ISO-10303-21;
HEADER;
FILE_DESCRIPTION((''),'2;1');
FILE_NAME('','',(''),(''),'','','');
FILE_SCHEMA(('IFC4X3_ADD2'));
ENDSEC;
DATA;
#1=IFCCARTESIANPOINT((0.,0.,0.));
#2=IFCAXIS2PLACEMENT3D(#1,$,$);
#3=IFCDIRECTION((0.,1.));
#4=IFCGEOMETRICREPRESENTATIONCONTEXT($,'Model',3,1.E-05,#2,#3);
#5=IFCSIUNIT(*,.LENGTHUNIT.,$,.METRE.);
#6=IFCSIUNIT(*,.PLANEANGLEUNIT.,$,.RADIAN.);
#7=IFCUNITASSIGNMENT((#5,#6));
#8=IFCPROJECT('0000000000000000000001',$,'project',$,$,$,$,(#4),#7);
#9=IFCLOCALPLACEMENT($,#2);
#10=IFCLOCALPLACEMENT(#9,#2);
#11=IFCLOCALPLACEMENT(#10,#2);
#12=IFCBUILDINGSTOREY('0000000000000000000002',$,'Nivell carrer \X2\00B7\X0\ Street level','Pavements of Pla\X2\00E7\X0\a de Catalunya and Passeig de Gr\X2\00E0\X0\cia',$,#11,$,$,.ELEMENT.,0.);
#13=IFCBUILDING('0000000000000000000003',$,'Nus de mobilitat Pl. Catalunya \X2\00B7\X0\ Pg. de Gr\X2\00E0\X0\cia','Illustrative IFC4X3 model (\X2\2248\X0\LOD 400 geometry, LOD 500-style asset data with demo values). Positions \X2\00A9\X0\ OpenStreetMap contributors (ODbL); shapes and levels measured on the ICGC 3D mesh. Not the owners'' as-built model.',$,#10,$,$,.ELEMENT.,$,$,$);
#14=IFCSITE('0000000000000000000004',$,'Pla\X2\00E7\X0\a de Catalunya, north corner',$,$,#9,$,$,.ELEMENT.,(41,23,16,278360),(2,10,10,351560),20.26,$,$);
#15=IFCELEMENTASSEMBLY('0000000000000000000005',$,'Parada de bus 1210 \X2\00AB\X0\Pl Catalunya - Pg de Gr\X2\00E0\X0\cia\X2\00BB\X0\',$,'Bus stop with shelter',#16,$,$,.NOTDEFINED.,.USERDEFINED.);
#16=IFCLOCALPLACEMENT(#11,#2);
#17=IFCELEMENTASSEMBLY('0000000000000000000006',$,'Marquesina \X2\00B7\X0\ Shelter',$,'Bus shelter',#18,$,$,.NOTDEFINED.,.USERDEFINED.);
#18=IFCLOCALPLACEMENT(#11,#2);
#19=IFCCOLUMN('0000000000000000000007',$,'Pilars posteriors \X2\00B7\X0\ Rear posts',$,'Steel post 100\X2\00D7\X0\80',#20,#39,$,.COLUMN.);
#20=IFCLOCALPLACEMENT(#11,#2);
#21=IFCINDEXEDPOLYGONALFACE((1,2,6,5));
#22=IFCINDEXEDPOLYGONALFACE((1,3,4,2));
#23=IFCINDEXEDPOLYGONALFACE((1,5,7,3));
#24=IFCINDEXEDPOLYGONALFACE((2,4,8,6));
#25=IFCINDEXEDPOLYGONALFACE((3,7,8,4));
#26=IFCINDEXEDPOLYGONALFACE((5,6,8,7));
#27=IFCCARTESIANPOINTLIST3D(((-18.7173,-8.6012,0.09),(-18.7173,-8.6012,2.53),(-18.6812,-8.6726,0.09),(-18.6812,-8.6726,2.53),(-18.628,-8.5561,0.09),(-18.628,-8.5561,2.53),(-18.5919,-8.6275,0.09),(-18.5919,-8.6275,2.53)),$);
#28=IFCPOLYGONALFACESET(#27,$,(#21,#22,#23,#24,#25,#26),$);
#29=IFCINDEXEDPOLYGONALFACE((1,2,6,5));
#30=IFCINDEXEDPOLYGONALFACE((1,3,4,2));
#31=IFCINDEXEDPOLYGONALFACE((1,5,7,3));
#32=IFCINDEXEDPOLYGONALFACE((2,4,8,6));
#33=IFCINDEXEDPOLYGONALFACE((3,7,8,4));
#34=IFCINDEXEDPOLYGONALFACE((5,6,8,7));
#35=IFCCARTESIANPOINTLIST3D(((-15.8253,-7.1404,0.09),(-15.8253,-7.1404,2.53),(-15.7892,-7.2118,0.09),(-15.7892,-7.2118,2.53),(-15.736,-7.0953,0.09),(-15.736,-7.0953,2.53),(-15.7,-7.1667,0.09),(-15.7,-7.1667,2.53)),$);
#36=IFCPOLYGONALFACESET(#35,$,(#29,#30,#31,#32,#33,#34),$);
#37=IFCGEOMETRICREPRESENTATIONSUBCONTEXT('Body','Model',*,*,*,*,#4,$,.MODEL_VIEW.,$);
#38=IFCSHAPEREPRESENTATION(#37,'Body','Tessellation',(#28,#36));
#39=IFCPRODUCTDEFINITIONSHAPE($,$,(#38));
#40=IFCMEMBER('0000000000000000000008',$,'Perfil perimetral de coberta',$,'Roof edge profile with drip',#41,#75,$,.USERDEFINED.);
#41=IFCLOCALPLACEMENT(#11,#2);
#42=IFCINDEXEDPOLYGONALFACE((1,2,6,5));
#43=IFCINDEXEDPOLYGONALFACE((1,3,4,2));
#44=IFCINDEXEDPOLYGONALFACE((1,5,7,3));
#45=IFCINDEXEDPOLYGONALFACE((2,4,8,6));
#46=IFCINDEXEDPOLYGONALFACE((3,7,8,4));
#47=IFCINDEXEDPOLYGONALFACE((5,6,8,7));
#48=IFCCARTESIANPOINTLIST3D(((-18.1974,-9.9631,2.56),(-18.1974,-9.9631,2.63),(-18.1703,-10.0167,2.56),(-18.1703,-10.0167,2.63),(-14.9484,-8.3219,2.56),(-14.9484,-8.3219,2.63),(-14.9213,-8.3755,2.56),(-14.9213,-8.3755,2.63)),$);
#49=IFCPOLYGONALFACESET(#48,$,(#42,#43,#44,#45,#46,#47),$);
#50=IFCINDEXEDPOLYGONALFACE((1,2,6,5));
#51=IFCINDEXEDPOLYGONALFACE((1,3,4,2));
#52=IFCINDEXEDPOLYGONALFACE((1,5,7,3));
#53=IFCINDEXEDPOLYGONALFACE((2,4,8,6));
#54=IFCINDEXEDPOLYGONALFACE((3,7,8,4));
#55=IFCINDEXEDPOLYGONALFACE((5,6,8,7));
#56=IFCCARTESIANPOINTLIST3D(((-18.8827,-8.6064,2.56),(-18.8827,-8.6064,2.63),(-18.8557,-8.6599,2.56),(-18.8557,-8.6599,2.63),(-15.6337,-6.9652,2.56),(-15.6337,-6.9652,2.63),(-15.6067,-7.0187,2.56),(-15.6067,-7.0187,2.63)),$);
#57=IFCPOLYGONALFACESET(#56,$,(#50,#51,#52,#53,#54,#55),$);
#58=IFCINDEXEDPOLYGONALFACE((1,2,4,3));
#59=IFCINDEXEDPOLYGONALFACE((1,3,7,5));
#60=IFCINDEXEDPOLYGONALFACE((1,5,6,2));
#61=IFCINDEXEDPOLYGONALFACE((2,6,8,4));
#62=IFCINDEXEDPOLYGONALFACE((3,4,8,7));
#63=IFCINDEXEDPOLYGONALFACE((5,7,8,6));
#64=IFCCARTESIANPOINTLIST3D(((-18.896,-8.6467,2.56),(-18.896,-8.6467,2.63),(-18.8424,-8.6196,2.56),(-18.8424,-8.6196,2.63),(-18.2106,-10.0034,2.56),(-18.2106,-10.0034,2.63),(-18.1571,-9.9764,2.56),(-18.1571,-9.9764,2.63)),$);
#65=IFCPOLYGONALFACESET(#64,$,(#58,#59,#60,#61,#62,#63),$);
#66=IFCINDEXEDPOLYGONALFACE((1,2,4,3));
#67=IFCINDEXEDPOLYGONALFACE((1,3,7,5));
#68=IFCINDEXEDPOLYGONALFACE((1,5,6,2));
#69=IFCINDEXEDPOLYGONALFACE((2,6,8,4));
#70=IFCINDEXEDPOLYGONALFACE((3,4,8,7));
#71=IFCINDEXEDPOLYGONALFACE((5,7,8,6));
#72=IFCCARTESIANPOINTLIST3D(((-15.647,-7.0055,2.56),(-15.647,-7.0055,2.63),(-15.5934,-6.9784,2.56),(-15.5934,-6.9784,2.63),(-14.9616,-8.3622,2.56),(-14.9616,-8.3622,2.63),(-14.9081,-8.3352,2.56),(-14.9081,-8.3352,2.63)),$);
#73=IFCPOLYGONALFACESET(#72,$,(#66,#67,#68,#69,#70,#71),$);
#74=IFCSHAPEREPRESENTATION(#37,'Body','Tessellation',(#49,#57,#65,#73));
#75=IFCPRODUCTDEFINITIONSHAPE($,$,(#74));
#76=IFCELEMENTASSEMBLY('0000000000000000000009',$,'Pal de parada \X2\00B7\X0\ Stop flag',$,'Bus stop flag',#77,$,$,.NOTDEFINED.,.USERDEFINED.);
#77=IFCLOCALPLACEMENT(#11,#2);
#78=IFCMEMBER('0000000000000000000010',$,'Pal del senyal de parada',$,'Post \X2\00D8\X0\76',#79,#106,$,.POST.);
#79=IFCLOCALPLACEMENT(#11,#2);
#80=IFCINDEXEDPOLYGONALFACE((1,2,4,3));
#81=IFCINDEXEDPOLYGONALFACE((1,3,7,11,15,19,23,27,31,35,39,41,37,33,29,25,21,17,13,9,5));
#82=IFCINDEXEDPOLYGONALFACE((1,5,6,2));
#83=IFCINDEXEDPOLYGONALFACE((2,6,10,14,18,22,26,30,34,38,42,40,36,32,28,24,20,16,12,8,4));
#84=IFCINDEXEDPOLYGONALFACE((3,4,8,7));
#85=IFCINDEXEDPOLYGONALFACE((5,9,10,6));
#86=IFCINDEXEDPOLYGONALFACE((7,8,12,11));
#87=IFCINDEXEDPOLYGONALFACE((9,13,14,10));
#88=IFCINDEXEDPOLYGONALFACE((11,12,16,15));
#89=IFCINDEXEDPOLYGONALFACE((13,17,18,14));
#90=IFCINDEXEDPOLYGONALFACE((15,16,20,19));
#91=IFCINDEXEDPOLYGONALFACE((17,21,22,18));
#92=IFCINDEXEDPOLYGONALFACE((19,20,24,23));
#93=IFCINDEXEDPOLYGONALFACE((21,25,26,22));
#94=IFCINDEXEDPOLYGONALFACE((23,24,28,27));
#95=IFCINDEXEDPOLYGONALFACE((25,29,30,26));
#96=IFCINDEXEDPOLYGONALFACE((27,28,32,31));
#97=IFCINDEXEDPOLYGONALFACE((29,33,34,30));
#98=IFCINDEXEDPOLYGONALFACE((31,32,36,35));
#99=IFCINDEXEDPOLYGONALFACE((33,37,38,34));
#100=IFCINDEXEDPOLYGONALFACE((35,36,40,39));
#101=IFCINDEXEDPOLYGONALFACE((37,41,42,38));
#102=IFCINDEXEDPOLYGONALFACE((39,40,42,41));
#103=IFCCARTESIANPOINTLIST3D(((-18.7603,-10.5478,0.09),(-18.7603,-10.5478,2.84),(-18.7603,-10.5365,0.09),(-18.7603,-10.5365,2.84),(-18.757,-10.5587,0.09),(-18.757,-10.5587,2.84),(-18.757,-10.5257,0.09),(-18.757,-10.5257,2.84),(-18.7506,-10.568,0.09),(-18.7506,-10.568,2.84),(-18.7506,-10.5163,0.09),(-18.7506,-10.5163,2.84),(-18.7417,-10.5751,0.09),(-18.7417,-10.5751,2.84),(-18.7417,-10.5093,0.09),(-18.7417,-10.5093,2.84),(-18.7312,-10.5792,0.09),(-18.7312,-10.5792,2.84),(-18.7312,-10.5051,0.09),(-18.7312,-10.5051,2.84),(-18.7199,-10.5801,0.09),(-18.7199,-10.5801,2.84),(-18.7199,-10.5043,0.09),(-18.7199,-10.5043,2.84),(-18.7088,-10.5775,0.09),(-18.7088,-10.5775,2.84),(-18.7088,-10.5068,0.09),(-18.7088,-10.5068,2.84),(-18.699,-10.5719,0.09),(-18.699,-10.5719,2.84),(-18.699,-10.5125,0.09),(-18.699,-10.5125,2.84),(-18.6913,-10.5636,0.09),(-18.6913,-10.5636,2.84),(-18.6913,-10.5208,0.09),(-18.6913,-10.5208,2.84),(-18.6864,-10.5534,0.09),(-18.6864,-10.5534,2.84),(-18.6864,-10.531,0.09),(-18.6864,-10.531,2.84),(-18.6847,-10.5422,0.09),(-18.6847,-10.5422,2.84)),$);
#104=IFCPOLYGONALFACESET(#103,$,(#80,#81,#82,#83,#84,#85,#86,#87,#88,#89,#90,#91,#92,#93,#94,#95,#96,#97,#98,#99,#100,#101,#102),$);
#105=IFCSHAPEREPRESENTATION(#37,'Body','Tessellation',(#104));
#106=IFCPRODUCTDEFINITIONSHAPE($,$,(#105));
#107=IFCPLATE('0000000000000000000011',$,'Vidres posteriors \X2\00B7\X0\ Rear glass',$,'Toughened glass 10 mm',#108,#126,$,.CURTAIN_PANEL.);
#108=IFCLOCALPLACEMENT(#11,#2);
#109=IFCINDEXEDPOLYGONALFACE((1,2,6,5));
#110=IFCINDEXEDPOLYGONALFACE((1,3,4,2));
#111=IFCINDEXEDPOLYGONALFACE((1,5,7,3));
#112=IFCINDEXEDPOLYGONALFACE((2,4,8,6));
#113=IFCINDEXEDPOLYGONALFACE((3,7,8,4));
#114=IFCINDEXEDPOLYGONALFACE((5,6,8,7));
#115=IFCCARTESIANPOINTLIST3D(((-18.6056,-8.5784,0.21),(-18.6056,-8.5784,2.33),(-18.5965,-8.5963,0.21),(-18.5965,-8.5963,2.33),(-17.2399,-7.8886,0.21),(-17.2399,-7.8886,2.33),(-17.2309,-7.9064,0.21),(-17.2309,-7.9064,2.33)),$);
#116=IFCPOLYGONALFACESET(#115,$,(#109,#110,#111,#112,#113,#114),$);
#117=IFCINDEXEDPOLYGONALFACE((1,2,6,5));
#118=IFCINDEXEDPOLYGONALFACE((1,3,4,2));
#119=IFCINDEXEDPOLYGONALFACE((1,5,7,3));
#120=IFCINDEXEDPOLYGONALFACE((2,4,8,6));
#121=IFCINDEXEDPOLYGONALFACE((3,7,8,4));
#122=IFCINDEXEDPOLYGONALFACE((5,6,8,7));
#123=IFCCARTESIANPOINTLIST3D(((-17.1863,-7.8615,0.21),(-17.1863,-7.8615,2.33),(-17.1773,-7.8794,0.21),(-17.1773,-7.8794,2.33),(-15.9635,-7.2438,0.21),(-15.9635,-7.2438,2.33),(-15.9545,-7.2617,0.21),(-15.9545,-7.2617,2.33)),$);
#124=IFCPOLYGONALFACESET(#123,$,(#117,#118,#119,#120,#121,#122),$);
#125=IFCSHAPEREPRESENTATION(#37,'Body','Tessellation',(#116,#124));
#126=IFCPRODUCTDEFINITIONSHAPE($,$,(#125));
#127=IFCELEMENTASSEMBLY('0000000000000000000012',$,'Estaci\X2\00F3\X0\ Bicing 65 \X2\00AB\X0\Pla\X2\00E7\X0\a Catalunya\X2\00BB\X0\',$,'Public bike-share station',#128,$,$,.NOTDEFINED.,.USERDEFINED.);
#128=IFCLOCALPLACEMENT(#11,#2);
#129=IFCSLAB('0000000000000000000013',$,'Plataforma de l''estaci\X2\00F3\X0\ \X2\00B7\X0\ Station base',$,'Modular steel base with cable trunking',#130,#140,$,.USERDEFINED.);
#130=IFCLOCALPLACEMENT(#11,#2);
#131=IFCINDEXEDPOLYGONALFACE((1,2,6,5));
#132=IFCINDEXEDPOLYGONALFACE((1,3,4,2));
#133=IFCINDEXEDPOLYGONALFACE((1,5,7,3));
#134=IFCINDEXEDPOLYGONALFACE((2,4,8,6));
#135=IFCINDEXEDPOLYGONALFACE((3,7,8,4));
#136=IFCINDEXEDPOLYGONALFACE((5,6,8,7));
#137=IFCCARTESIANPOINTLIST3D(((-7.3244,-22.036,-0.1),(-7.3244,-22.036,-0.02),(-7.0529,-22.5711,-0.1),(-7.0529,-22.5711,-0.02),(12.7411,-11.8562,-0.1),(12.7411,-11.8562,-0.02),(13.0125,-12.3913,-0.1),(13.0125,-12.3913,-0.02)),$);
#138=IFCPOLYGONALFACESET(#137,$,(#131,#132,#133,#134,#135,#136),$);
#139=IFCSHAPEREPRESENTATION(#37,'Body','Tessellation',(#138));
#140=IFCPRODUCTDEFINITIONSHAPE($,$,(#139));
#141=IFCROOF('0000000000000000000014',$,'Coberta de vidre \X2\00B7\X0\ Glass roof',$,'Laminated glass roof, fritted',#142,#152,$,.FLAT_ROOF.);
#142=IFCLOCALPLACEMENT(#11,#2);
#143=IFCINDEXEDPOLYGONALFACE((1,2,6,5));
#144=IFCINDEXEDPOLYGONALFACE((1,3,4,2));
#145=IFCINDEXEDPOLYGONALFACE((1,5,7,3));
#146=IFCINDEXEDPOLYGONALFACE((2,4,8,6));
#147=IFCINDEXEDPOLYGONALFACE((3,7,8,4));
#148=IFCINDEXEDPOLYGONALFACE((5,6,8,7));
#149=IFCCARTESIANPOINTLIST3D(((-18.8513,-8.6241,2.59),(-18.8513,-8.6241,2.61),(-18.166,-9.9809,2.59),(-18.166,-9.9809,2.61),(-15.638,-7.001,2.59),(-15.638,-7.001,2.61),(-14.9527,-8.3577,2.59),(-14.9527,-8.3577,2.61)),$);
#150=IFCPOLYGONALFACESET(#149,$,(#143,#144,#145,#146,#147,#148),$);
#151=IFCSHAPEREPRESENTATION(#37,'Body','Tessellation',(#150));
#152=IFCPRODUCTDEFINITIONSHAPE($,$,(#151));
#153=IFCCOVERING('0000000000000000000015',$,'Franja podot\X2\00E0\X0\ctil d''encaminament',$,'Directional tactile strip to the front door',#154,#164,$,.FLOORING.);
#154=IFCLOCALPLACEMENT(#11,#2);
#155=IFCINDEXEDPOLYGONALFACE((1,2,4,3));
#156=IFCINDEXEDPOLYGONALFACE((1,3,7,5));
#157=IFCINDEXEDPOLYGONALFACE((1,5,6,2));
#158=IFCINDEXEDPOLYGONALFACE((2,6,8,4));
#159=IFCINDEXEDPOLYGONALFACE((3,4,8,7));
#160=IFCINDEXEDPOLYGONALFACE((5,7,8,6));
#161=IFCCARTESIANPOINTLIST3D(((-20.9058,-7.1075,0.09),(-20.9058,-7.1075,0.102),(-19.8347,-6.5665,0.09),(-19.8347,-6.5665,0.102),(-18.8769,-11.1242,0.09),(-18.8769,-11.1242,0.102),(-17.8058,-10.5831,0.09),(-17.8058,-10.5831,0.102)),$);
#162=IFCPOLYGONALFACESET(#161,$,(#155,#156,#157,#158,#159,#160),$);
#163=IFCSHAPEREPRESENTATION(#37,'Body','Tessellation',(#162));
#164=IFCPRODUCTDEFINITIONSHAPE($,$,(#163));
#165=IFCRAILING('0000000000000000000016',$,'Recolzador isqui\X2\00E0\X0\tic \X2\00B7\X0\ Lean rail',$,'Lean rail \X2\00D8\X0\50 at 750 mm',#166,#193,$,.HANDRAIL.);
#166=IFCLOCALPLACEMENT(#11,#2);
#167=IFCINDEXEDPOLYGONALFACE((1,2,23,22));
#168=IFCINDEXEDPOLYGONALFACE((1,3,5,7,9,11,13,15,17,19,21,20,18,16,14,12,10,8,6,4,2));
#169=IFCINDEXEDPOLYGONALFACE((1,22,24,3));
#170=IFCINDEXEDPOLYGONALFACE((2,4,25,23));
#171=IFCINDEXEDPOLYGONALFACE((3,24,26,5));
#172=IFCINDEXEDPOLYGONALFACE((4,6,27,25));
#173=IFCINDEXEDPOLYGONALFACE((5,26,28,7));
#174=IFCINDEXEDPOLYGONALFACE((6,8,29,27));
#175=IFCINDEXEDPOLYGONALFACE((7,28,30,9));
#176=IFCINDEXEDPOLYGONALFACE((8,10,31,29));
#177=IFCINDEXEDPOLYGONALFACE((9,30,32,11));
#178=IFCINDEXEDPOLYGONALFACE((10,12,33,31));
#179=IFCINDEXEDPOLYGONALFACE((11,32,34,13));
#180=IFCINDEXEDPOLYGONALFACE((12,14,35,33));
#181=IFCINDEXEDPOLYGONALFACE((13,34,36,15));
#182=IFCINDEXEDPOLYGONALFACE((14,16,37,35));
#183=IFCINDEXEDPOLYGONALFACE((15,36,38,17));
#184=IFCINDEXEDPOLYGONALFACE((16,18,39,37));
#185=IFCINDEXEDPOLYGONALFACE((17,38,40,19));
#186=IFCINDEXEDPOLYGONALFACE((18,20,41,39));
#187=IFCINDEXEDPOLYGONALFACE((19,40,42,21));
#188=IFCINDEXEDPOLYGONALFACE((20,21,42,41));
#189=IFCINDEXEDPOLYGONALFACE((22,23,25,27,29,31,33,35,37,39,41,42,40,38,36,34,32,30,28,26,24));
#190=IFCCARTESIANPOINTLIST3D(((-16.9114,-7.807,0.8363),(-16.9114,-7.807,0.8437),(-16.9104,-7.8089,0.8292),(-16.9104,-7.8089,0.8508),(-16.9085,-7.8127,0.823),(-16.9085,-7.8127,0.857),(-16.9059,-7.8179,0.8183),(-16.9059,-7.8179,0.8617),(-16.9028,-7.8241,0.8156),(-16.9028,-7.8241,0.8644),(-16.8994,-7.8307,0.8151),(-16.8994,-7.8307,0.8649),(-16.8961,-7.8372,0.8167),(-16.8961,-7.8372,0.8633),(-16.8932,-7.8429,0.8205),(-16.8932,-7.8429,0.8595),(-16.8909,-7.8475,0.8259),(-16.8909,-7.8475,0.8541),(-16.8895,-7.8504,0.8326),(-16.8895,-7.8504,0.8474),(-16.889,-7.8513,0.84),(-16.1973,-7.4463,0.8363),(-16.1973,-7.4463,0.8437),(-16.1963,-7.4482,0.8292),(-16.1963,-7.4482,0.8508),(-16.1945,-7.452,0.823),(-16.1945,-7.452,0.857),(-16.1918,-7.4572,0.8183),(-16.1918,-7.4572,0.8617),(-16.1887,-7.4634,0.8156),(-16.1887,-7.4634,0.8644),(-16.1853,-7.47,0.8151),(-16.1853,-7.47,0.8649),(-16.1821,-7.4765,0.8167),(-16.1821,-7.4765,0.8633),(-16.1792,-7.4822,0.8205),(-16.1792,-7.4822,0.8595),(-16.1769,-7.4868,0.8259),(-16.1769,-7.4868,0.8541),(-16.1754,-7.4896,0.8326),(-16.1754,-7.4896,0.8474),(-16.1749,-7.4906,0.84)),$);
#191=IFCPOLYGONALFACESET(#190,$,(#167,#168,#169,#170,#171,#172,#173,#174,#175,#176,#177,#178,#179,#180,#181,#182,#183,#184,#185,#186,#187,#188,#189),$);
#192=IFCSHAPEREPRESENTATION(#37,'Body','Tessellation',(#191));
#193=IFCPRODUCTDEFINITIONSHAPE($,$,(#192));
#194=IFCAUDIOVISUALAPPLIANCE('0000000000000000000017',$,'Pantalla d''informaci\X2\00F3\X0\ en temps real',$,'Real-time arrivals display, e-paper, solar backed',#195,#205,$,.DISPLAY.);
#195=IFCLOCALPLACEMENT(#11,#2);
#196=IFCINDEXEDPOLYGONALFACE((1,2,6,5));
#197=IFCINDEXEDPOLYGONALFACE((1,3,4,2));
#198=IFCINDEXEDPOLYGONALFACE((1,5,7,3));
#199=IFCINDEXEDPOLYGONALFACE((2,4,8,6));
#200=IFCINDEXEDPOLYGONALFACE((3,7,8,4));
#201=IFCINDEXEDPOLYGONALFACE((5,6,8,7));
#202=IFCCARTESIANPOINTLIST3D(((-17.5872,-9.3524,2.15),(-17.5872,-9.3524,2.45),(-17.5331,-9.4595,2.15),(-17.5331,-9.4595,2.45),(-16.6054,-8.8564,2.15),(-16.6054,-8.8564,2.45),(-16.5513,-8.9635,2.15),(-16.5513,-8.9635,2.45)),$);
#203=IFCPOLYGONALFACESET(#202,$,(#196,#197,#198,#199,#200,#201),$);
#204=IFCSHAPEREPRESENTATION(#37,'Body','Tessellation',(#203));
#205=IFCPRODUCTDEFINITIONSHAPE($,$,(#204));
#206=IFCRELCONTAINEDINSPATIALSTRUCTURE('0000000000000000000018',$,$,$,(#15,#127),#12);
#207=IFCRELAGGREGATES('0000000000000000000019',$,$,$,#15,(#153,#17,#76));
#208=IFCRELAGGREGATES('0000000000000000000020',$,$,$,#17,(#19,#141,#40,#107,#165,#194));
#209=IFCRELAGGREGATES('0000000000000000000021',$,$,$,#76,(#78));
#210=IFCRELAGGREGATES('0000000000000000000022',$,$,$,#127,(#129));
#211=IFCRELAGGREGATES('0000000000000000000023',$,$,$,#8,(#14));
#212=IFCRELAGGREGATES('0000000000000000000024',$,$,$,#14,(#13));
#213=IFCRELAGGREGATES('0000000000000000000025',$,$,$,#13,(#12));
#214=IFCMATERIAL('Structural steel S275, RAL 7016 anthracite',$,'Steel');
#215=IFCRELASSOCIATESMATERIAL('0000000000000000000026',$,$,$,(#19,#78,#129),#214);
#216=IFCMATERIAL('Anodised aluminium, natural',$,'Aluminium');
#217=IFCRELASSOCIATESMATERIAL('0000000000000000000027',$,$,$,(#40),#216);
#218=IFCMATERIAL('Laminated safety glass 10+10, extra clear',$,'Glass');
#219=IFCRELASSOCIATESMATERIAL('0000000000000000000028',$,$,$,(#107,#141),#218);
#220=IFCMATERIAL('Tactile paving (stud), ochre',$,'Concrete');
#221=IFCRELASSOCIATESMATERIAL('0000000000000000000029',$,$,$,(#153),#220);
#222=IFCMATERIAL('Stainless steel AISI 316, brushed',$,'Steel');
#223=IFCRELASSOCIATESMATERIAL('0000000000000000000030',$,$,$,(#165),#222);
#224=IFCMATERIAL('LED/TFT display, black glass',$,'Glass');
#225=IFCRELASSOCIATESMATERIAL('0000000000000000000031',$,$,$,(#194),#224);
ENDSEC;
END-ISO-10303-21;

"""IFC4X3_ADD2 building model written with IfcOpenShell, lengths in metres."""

from ifc_helpers import new_model, si_unit, direction, frame, frame_2d, origin, origin_2d_with_axis, place, context, subcontext, project, spatial, rectangle, circle, extrude, material, element, aggregate, save


model = new_model("IFC4X3_ADD2")

# Units and contexts
model_context = context("Model", 3, precision=1e-05, world=origin(), true_north=direction((0.0, 1.0)))
body_context = subcontext(model_context, "Body", "Model", "MODEL_VIEW")
ifc_project = project(units=[si_unit("LENGTHUNIT", "METRE"), si_unit("PLANEANGLEUNIT", "RADIAN")], contexts=[model_context])

# Site, building, storey
site_placement = place(None, origin())
site = spatial("IfcSite", under=ifc_project, at=site_placement, Name="Plaça de Catalunya, north corner", CompositionType="ELEMENT", RefLatitude=(41, 23, 16, 278360), RefLongitude=(2, 10, 10, 351560), RefElevation=20.26)
building_placement = place(site_placement, origin())
building = spatial("IfcBuilding", under=site, at=building_placement, Name="Nus de mobilitat Pl. Catalunya · Pg. de Gràcia", Description="Illustrative IFC4X3 model (≈LOD 400 geometry, LOD 500-style asset data with demo values). Positions © OpenStreetMap contributors (ODbL); shapes and levels measured on the ICGC 3D mesh. Not the owners' as-built model.", CompositionType="ELEMENT")
storey_placement = place(building_placement, origin())
storey = spatial("IfcBuildingStorey", under=building, at=storey_placement, Name="Nivell carrer · Street level", Description="Pavements of Plaça de Catalunya and Passeig de Gràcia", CompositionType="ELEMENT", Elevation=0.0)

# Element assemblies, column, members, plate
assembly_1_placement = place(building_placement, origin())
assembly_1 = element("IfcElementAssembly", 1, at=assembly_1_placement, inside=storey, Name="Parada de bus 1210 «Pl Catalunya - Pg de Gràcia»", ObjectType="Bus stop with shelter", AssemblyPlace="NOTDEFINED", PredefinedType="USERDEFINED")
assembly_2_placement = place(building_placement, origin())
assembly_2 = element("IfcElementAssembly", 2, at=assembly_2_placement, Name="Marquesina · Shelter", ObjectType="Bus shelter", AssemblyPlace="NOTDEFINED", PredefinedType="USERDEFINED")
ifc_material_1 = material(Name="Structural steel S275, RAL 7016 anthracite", Category="Steel")
column_placement = place(building_placement, origin())
column = element("IfcColumn", 3, at=column_placement, material=ifc_material_1, Name="Pilars posteriors · Rear posts", ObjectType="Steel post 100×80", PredefinedType="COLUMN", context=body_context, shape_type="SweptSolid", body=[
    extrude(rectangle(XDim=0.1, YDim=0.08, at=frame_2d((0.0, 0.0), x_axis=(0.892586, 0.450878))), frame((-18.6546, -8.6144, 0.09)), (0.0, 0.0, 1.0), 2.44),
    extrude(rectangle(XDim=0.1, YDim=0.08, at=frame_2d((0.0, 0.0), x_axis=(0.892586, 0.450878))), frame((-15.7626, -7.1535, 0.09)), (0.0, 0.0, 1.0), 2.44),
])
ifc_material_2 = material(Name="Anodised aluminium, natural", Category="Aluminium")
member_1_placement = place(building_placement, origin())
member_1 = element("IfcMember", 4, at=member_1_placement, material=ifc_material_2, Name="Perfil perimetral de coberta", ObjectType="Roof edge profile with drip", PredefinedType="USERDEFINED", context=body_context, shape_type="SweptSolid", body=[
    extrude(rectangle(XDim=3.64, YDim=0.06, at=frame_2d((0.0, 0.0), x_axis=(0.892586, 0.450878))), frame((-16.5594, -9.1693, 2.56)), (0.0, 0.0, 1.0), 0.07),
    extrude(rectangle(XDim=3.64, YDim=0.06, at=frame_2d((0.0, 0.0), x_axis=(0.892586, 0.450878))), frame((-17.2447, -7.8126, 2.56)), (0.0, 0.0, 1.0), 0.07),
    extrude(rectangle(XDim=0.06, YDim=1.52, at=frame_2d((0.0, 0.0), x_axis=(0.892586, 0.450878))), frame((-18.5265, -9.3115, 2.56)), (0.0, 0.0, 1.0), 0.07),
    extrude(rectangle(XDim=0.06, YDim=1.52, at=frame_2d((0.0, 0.0), x_axis=(0.892586, 0.450878))), frame((-15.2775, -7.6703, 2.56)), (0.0, 0.0, 1.0), 0.07),
])
assembly_3_placement = place(building_placement, origin())
assembly_3 = element("IfcElementAssembly", 5, at=assembly_3_placement, Name="Pal de parada · Stop flag", ObjectType="Bus stop flag", AssemblyPlace="NOTDEFINED", PredefinedType="USERDEFINED")
member_2_placement = place(building_placement, origin())
member_2 = element("IfcMember", 6, at=member_2_placement, material=ifc_material_1, Name="Pal del senyal de parada", ObjectType="Post Ø76", PredefinedType="POST", context=body_context, shape_type="SweptSolid", body=[
    extrude(circle(Radius=0.038, at=origin_2d_with_axis()), frame((-18.7227, -10.5422, 0.09)), (0.0, 0.0, 1.0), 2.75),
])
ifc_material_3 = material(Name="Laminated safety glass 10+10, extra clear", Category="Glass")
plate_placement = place(building_placement, origin())
plate = element("IfcPlate", 7, at=plate_placement, material=ifc_material_3, Name="Vidres posteriors · Rear glass", ObjectType="Toughened glass 10 mm", PredefinedType="CURTAIN_PANEL", context=body_context, shape_type="SweptSolid", body=[
    extrude(rectangle(XDim=1.53, YDim=0.02, at=frame_2d((0.0, 0.0), x_axis=(0.892586, 0.450878))), frame((-17.9182, -8.2424, 0.21)), (0.0, 0.0, 1.0), 2.12),
    extrude(rectangle(XDim=1.37, YDim=0.02, at=frame_2d((0.0, 0.0), x_axis=(0.892586, 0.450878))), frame((-16.5704, -7.5616, 0.21)), (0.0, 0.0, 1.0), 2.12),
])

# Element assembly, slab
assembly_4_placement = place(building_placement, origin())
assembly_4 = element("IfcElementAssembly", 8, at=assembly_4_placement, inside=storey, Name="Estació Bicing 65 «Plaça Catalunya»", ObjectType="Public bike-share station", AssemblyPlace="NOTDEFINED", PredefinedType="USERDEFINED")
slab_placement = place(building_placement, origin())
slab = element("IfcSlab", 9, at=slab_placement, material=ifc_material_1, Name="Plataforma de l'estació · Station base", ObjectType="Modular steel base with cable trunking", PredefinedType="USERDEFINED", context=body_context, shape_type="SweptSolid", body=[
    extrude(rectangle(XDim=22.5, YDim=0.6, at=frame_2d((0.0, 0.0), x_axis=(0.891798, 0.452435))), frame((2.8441, -17.2136, -0.1)), (0.0, 0.0, 1.0), 0.08),
])

# Roof
roof_placement = place(building_placement, origin())
roof = element("IfcRoof", 10, at=roof_placement, material=ifc_material_3, Name="Coberta de vidre · Glass roof", ObjectType="Laminated glass roof, fritted", PredefinedType="FLAT_ROOF", context=body_context, shape_type="SweptSolid", body=[
    extrude(rectangle(XDim=3.6, YDim=1.52, at=frame_2d((0.0, 0.0), x_axis=(0.892586, 0.450878))), frame((-16.902, -8.4909, 2.59)), (0.0, 0.0, 1.0), 0.02),
])

# Covering
ifc_material_4 = material(Name="Tactile paving (stud), ochre", Category="Concrete")
covering_placement = place(building_placement, origin())
covering = element("IfcCovering", 11, at=covering_placement, material=ifc_material_4, Name="Franja podotàctil d'encaminament", ObjectType="Directional tactile strip to the front door", PredefinedType="FLOORING", context=body_context, shape_type="SweptSolid", body=[
    extrude(rectangle(XDim=1.2, YDim=4.5, at=frame_2d((0.0, 0.0), x_axis=(0.892586, 0.450878))), frame((-19.3558, -8.8453, 0.09)), (0.0, 0.0, 1.0), 0.012),
])

# Railing
ifc_material_5 = material(Name="Stainless steel AISI 316, brushed", Category="Steel")
railing_placement = place(building_placement, origin())
railing = element("IfcRailing", 12, at=railing_placement, material=ifc_material_5, Name="Recolzador isquiàtic · Lean rail", ObjectType="Lean rail Ø50 at 750 mm", PredefinedType="HANDRAIL", context=body_context, shape_type="SweptSolid", body=[
    extrude(circle(Radius=0.025, at=origin_2d_with_axis()), frame((-16.9003, -7.829, 0.84), z_axis=(0.892586, 0.450878, 0.0), x_axis=(0.450878, -0.892586, 0.0)), (0.0, 0.0, 1.0), 0.8),
])

# Audio visual appliance
ifc_material_6 = material(Name="LED/TFT display, black glass", Category="Glass")
audio_visual_appliance_placement = place(building_placement, origin())
audio_visual_appliance = element("IfcAudioVisualAppliance", 13, at=audio_visual_appliance_placement, material=ifc_material_6, Name="Pantalla d'informació en temps real", ObjectType="Real-time arrivals display, e-paper, solar backed", PredefinedType="DISPLAY", context=body_context, shape_type="SweptSolid", body=[
    extrude(rectangle(XDim=1.1, YDim=0.12, at=frame_2d((0.0, 0.0), x_axis=(0.892586, 0.450878))), frame((-17.0692, -9.158, 2.15)), (0.0, 0.0, 1.0), 0.3),
])

aggregate(assembly_1, [covering, assembly_2, assembly_3])

aggregate(assembly_2, [column, roof, member_1, plate, railing, audio_visual_appliance])
aggregate(assembly_3, [member_2])

aggregate(assembly_4, [slab])

save(model, "model.ifc")
